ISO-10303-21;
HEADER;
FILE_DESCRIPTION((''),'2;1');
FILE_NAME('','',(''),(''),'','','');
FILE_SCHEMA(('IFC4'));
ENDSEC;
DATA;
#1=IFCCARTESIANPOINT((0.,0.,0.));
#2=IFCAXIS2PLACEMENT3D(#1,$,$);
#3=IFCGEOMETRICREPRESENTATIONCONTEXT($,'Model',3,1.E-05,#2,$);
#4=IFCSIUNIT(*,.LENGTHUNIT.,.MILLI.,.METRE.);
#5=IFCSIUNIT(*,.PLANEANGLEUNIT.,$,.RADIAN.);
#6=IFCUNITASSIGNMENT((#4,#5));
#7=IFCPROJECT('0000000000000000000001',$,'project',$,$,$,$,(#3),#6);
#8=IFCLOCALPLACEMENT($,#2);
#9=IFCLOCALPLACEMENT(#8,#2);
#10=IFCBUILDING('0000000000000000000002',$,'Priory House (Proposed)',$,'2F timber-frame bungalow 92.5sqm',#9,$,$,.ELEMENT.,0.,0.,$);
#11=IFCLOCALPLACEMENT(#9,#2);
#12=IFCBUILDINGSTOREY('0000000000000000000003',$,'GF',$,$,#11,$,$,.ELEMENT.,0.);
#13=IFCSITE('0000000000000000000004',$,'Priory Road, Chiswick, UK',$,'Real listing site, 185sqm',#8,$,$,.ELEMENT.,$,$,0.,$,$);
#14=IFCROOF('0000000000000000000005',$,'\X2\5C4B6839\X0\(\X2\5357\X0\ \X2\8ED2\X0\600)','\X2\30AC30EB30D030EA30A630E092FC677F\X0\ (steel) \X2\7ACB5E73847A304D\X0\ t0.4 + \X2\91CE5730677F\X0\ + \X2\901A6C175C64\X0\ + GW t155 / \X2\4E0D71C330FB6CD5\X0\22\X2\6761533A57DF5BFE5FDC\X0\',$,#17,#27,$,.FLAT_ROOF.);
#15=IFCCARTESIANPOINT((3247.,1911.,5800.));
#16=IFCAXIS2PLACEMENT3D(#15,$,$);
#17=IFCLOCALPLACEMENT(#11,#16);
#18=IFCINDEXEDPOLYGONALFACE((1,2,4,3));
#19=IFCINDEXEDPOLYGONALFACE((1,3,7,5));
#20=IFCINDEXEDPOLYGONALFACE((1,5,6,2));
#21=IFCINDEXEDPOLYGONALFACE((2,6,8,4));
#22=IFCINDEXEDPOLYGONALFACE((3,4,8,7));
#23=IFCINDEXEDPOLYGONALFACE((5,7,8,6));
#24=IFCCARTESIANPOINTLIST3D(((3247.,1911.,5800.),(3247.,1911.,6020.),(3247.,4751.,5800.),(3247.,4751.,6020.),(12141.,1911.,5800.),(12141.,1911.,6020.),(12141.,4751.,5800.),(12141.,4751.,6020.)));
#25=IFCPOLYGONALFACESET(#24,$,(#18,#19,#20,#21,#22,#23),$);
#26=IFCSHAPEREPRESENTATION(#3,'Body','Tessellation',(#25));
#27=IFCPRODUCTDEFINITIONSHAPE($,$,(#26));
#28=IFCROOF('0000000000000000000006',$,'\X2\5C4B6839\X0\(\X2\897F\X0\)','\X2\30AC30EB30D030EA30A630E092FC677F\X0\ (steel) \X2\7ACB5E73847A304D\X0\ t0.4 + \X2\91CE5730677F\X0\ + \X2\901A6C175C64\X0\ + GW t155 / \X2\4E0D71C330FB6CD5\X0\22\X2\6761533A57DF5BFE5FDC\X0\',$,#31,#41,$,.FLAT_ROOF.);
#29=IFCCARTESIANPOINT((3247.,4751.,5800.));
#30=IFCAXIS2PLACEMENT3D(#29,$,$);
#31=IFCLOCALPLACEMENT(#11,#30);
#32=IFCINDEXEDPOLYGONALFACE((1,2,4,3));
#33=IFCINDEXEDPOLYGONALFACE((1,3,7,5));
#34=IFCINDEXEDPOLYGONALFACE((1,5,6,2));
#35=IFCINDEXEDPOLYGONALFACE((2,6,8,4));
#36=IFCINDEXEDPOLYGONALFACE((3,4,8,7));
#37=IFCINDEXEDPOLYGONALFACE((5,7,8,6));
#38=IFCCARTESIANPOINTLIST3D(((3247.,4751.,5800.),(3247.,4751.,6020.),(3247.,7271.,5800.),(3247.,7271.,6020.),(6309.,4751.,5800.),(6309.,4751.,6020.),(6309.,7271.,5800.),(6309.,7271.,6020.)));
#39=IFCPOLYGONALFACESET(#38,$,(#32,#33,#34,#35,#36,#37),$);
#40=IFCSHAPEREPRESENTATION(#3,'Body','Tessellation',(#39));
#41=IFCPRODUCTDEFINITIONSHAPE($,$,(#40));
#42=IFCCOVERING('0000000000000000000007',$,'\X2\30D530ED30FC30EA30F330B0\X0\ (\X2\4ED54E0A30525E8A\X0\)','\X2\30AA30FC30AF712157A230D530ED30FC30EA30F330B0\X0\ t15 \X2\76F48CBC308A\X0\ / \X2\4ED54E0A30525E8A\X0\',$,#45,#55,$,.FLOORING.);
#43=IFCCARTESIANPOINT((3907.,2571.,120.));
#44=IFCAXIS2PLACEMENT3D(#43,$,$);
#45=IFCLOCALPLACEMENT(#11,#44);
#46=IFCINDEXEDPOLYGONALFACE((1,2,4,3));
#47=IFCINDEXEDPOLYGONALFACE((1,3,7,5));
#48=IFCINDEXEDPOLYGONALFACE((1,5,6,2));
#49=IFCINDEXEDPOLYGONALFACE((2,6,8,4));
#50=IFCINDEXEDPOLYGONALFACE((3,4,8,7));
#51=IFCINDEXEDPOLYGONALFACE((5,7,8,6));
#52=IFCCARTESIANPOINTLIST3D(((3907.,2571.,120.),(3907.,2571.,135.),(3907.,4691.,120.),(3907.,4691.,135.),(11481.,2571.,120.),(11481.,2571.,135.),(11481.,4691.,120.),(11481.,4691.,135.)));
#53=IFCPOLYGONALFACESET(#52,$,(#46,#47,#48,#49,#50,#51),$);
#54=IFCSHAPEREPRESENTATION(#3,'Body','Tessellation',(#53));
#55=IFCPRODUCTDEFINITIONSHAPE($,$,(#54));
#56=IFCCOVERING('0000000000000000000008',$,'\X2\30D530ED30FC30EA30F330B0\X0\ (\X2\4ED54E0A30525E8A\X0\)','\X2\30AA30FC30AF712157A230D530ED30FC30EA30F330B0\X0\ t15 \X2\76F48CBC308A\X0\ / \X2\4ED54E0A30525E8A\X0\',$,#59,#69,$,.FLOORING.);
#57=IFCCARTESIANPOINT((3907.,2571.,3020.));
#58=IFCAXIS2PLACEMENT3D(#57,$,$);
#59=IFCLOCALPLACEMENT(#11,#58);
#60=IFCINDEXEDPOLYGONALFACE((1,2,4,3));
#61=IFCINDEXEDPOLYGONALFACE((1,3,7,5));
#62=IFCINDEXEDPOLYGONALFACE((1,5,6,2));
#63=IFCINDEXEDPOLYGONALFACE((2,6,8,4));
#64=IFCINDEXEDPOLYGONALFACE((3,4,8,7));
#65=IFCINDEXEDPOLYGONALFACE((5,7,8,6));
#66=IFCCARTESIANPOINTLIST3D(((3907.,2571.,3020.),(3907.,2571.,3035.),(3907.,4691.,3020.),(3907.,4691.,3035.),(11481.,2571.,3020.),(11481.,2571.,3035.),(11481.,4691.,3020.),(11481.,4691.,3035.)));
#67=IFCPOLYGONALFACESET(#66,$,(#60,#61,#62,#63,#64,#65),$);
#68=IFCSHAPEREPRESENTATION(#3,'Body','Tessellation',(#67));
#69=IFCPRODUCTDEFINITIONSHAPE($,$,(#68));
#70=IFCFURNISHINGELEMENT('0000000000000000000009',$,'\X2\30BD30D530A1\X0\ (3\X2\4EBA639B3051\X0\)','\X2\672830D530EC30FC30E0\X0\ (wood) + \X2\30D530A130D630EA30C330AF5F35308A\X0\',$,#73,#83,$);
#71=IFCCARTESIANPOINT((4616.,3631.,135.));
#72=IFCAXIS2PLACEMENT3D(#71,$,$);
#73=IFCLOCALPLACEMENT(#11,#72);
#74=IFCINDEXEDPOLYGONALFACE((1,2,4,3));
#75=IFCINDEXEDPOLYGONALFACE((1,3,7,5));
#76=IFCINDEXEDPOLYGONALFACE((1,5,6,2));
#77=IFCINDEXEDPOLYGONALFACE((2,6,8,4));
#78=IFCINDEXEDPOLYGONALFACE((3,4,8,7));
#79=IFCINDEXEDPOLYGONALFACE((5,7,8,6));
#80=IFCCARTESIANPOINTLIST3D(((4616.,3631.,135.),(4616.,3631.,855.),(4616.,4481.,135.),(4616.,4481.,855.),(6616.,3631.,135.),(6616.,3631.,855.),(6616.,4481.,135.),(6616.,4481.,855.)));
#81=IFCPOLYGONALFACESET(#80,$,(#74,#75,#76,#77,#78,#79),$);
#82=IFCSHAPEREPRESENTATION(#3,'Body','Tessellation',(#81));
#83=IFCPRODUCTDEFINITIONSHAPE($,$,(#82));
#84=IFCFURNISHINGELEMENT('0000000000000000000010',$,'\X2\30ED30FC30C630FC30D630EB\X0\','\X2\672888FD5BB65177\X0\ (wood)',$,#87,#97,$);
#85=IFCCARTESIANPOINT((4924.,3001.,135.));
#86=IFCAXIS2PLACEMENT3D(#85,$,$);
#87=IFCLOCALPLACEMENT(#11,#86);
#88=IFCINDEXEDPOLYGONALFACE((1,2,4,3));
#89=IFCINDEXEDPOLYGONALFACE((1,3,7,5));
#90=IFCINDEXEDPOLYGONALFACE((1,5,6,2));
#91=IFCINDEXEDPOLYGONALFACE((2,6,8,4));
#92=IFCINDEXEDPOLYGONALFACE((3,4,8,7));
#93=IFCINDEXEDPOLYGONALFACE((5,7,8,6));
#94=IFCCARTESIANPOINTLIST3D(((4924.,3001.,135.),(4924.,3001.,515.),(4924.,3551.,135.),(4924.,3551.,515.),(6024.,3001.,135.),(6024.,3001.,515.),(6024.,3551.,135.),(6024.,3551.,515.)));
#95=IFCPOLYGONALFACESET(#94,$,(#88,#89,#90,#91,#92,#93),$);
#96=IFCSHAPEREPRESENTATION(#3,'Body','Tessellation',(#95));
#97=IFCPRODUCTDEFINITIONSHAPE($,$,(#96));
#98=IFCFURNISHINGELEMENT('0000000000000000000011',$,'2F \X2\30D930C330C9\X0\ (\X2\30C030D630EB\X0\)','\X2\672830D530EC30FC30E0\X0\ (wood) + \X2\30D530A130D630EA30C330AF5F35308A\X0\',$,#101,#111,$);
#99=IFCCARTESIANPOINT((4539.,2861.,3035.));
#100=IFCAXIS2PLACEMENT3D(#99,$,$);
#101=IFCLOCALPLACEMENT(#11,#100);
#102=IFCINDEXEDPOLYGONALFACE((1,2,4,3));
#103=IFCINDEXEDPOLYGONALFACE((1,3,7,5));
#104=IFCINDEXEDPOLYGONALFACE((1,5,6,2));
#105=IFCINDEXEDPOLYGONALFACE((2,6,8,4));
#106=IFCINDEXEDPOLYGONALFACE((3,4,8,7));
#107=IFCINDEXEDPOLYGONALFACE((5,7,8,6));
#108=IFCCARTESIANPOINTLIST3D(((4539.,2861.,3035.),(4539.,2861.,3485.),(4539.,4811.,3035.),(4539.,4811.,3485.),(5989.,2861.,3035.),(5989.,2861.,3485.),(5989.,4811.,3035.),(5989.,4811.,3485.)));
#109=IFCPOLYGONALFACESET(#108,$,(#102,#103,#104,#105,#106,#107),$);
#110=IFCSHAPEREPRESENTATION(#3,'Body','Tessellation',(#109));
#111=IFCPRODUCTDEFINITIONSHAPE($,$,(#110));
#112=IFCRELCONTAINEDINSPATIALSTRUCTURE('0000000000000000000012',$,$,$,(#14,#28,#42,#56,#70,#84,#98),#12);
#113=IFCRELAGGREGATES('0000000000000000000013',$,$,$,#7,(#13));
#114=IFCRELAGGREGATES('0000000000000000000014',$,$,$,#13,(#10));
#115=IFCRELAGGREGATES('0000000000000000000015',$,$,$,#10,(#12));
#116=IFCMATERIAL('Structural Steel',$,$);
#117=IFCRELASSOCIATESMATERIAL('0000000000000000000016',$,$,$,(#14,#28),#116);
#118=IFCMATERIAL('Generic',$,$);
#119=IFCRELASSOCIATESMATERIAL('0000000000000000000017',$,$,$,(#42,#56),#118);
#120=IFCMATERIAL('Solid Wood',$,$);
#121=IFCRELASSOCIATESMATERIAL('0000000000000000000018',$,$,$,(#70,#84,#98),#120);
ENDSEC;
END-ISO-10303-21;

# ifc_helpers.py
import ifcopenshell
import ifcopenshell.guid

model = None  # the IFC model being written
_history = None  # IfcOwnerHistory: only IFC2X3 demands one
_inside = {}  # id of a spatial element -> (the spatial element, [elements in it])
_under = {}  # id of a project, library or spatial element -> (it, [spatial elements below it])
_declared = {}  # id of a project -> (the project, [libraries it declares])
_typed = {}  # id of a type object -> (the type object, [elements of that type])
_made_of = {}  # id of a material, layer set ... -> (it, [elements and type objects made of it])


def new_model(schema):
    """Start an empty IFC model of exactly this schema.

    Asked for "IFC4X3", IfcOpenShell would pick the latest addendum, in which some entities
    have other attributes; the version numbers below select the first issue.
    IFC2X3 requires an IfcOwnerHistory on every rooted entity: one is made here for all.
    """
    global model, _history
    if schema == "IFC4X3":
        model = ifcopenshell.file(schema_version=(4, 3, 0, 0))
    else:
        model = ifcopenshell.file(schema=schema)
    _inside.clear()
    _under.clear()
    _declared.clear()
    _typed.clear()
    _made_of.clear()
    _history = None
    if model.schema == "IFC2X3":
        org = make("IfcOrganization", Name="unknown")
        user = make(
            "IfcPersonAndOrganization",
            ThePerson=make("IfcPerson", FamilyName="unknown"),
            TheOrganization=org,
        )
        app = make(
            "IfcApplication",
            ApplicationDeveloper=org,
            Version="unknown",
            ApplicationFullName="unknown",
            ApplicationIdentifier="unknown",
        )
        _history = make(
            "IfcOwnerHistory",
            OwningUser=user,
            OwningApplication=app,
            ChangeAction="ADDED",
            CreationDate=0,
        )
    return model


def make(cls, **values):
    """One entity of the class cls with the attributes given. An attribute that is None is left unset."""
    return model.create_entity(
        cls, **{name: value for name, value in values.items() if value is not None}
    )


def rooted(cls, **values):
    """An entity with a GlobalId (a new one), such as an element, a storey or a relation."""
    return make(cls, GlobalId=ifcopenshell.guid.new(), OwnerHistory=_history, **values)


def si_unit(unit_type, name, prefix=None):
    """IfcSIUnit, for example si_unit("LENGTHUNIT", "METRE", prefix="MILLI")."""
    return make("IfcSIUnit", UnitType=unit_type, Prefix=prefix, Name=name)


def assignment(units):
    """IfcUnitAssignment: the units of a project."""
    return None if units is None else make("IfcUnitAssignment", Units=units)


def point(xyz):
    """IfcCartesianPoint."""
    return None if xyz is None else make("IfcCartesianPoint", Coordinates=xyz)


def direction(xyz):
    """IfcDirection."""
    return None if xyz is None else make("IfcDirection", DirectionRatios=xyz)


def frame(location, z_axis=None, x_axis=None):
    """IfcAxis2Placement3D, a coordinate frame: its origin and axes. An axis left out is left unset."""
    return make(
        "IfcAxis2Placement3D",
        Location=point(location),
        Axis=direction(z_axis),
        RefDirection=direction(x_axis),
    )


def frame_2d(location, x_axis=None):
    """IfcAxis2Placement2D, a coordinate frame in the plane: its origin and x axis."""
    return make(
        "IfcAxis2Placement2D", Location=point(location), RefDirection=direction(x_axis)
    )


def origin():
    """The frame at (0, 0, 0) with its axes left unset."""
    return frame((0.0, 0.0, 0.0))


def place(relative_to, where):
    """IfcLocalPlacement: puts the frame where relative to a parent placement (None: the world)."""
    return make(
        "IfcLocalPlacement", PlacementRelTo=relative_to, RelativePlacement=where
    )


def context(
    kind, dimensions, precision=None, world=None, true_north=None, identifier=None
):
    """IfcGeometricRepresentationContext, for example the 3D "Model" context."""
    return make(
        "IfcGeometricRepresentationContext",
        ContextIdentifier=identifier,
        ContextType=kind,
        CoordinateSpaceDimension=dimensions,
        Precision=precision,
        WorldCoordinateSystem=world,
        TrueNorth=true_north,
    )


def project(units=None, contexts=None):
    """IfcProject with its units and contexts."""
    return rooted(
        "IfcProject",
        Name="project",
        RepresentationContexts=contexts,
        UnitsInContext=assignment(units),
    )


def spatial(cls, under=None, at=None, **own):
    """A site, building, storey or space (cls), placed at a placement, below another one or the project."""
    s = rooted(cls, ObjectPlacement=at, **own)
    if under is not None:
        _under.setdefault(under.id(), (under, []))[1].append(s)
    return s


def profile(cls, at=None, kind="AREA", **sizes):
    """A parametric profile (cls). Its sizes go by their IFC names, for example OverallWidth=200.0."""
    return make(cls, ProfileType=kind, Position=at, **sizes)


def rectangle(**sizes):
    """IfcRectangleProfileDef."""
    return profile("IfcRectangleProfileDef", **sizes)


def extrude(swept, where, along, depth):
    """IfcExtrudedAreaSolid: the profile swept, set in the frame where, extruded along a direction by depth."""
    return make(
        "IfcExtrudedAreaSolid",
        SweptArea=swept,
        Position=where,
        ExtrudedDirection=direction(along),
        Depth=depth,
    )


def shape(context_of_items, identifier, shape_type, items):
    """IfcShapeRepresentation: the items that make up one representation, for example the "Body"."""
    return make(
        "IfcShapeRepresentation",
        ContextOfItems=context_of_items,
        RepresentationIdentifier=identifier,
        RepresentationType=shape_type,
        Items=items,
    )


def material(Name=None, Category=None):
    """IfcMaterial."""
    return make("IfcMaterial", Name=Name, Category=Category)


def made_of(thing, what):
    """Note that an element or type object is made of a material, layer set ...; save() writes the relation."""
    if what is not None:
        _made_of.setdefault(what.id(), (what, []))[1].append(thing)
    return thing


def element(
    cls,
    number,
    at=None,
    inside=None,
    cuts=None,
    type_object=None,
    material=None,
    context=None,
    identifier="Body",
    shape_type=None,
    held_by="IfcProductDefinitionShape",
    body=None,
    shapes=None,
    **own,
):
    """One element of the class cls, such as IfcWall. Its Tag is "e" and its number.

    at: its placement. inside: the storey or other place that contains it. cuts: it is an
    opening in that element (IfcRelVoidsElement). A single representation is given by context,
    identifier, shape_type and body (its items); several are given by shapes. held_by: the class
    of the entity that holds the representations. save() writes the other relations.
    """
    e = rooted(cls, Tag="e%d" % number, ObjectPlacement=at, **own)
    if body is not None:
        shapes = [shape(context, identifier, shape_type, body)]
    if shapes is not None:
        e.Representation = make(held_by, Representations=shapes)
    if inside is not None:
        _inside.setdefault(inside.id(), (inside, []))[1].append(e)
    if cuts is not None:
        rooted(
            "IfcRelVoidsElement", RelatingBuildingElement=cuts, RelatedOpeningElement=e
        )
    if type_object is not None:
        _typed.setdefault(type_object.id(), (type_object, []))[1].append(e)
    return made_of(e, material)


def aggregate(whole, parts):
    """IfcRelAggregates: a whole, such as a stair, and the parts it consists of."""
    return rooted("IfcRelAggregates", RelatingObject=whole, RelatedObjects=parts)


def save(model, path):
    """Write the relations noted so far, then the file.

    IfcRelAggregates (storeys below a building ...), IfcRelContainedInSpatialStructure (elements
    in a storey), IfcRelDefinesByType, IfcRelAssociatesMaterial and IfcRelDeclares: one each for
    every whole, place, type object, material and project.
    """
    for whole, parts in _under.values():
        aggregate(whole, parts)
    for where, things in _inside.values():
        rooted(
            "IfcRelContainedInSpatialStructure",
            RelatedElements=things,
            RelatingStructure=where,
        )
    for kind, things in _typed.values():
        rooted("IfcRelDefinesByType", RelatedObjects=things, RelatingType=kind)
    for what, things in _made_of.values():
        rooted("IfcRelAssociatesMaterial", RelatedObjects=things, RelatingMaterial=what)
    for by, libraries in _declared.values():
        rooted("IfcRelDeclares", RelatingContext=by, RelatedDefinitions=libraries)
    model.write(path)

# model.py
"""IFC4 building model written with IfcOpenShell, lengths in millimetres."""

from ifc_helpers import new_model, si_unit, frame, frame_2d, origin, place, context, project, spatial, rectangle, extrude, material, element, save


model = new_model("IFC4")

# Units and contexts
model_context = context("Model", 3, precision=1e-05, world=origin())
ifc_project = project(units=[si_unit("LENGTHUNIT", "METRE", prefix="MILLI"), si_unit("PLANEANGLEUNIT", "RADIAN")], contexts=[model_context])

# Site, building, storey
site_placement = place(None, origin())
site = spatial("IfcSite", under=ifc_project, at=site_placement, Name="Priory Road, Chiswick, UK", ObjectType="Real listing site, 185sqm", CompositionType="ELEMENT", RefElevation=0.0)
building_placement = place(site_placement, origin())
building = spatial("IfcBuilding", under=site, at=building_placement, Name="Priory House (Proposed)", ObjectType="2F timber-frame bungalow 92.5sqm", CompositionType="ELEMENT", ElevationOfRefHeight=0.0, ElevationOfTerrain=0.0)
storey_placement = place(building_placement, origin())
storey = spatial("IfcBuildingStorey", under=building, at=storey_placement, Name="GF", CompositionType="ELEMENT", Elevation=0.0)

# Shared definitions
ifc_material_1 = material(Name="Solid Wood")

# Roofs
ifc_material_2 = material(Name="Structural Steel")
roof_1_placement = place(storey_placement, frame((3247.0, 1911.0, 5800.0)))
element("IfcRoof", 1, at=roof_1_placement, inside=storey, material=ifc_material_2, Name="屋根(南 軒600)", Description="ガルバリウム鋼板 (steel) 立平葺き t0.4 + 野地板 + 通気層 + GW t155 / 不燃・法22条区域対応", PredefinedType="FLAT_ROOF", context=model_context, shape_type="SweptSolid", body=[
    extrude(rectangle(XDim=8894.0, YDim=2840.0, at=frame_2d((4447.0, 1420.0))), frame((3247.0, 1911.0, 5800.0)), (0.0, 0.0, 1.0), 220.0),
])
roof_2_placement = place(storey_placement, frame((3247.0, 4751.0, 5800.0)))
element("IfcRoof", 2, at=roof_2_placement, inside=storey, material=ifc_material_2, Name="屋根(西)", Description="ガルバリウム鋼板 (steel) 立平葺き t0.4 + 野地板 + 通気層 + GW t155 / 不燃・法22条区域対応", PredefinedType="FLAT_ROOF", context=model_context, shape_type="SweptSolid", body=[
    extrude(rectangle(XDim=3062.0, YDim=2520.0, at=frame_2d((1531.0, 1260.0))), frame((3247.0, 4751.0, 5800.0)), (0.0, 0.0, 1.0), 220.0),
])

# Coverings
ifc_material_3 = material(Name="Generic")
covering_1_placement = place(storey_placement, frame((3907.0, 2571.0, 120.0)))
element("IfcCovering", 3, at=covering_1_placement, inside=storey, material=ifc_material_3, Name="フローリング (仕上げ床)", Description="オーク無垢フローリング t15 直貼り / 仕上げ床", PredefinedType="FLOORING", context=model_context, shape_type="SweptSolid", body=[
    extrude(rectangle(XDim=7574.0, YDim=2120.0, at=frame_2d((3787.0, 1060.0))), frame((3907.0, 2571.0, 120.0)), (0.0, 0.0, 1.0), 15.0),
])
covering_2_placement = place(storey_placement, frame((3907.0, 2571.0, 3020.0)))
element("IfcCovering", 4, at=covering_2_placement, inside=storey, material=ifc_material_3, Name="フローリング (仕上げ床)", Description="オーク無垢フローリング t15 直貼り / 仕上げ床", PredefinedType="FLOORING", context=model_context, shape_type="SweptSolid", body=[
    extrude(rectangle(XDim=7574.0, YDim=2120.0, at=frame_2d((3787.0, 1060.0))), frame((3907.0, 2571.0, 3020.0)), (0.0, 0.0, 1.0), 15.0),
])

# Furnishing elements
furnishing_1_placement = place(storey_placement, frame((4616.0, 3631.0, 135.0)))
element("IfcFurnishingElement", 5, at=furnishing_1_placement, inside=storey, material=ifc_material_1, Name="ソファ (3人掛け)", Description="木フレーム (wood) + ファブリック張り", context=model_context, shape_type="SweptSolid", body=[
    extrude(rectangle(XDim=2000.0, YDim=850.0, at=frame_2d((1000.0, 425.0))), frame((4616.0, 3631.0, 135.0)), (0.0, 0.0, 1.0), 720.0),
])
furnishing_2_placement = place(storey_placement, frame((4924.0, 3001.0, 135.0)))
element("IfcFurnishingElement", 6, at=furnishing_2_placement, inside=storey, material=ifc_material_1, Name="ローテーブル", Description="木製家具 (wood)", context=model_context, shape_type="SweptSolid", body=[
    extrude(rectangle(XDim=1100.0, YDim=550.0, at=frame_2d((550.0, 275.0))), frame((4924.0, 3001.0, 135.0)), (0.0, 0.0, 1.0), 380.0),
])
furnishing_3_placement = place(storey_placement, frame((4539.0, 2861.0, 3035.0)))
element("IfcFurnishingElement", 7, at=furnishing_3_placement, inside=storey, material=ifc_material_1, Name="2F ベッド (ダブル)", Description="木フレーム (wood) + ファブリック張り", context=model_context, shape_type="SweptSolid", body=[
    extrude(rectangle(XDim=1450.0, YDim=1950.0, at=frame_2d((725.0, 975.0))), frame((4539.0, 2861.0, 3035.0)), (0.0, 0.0, 1.0), 450.0),
])

save(model, "model.ifc")
